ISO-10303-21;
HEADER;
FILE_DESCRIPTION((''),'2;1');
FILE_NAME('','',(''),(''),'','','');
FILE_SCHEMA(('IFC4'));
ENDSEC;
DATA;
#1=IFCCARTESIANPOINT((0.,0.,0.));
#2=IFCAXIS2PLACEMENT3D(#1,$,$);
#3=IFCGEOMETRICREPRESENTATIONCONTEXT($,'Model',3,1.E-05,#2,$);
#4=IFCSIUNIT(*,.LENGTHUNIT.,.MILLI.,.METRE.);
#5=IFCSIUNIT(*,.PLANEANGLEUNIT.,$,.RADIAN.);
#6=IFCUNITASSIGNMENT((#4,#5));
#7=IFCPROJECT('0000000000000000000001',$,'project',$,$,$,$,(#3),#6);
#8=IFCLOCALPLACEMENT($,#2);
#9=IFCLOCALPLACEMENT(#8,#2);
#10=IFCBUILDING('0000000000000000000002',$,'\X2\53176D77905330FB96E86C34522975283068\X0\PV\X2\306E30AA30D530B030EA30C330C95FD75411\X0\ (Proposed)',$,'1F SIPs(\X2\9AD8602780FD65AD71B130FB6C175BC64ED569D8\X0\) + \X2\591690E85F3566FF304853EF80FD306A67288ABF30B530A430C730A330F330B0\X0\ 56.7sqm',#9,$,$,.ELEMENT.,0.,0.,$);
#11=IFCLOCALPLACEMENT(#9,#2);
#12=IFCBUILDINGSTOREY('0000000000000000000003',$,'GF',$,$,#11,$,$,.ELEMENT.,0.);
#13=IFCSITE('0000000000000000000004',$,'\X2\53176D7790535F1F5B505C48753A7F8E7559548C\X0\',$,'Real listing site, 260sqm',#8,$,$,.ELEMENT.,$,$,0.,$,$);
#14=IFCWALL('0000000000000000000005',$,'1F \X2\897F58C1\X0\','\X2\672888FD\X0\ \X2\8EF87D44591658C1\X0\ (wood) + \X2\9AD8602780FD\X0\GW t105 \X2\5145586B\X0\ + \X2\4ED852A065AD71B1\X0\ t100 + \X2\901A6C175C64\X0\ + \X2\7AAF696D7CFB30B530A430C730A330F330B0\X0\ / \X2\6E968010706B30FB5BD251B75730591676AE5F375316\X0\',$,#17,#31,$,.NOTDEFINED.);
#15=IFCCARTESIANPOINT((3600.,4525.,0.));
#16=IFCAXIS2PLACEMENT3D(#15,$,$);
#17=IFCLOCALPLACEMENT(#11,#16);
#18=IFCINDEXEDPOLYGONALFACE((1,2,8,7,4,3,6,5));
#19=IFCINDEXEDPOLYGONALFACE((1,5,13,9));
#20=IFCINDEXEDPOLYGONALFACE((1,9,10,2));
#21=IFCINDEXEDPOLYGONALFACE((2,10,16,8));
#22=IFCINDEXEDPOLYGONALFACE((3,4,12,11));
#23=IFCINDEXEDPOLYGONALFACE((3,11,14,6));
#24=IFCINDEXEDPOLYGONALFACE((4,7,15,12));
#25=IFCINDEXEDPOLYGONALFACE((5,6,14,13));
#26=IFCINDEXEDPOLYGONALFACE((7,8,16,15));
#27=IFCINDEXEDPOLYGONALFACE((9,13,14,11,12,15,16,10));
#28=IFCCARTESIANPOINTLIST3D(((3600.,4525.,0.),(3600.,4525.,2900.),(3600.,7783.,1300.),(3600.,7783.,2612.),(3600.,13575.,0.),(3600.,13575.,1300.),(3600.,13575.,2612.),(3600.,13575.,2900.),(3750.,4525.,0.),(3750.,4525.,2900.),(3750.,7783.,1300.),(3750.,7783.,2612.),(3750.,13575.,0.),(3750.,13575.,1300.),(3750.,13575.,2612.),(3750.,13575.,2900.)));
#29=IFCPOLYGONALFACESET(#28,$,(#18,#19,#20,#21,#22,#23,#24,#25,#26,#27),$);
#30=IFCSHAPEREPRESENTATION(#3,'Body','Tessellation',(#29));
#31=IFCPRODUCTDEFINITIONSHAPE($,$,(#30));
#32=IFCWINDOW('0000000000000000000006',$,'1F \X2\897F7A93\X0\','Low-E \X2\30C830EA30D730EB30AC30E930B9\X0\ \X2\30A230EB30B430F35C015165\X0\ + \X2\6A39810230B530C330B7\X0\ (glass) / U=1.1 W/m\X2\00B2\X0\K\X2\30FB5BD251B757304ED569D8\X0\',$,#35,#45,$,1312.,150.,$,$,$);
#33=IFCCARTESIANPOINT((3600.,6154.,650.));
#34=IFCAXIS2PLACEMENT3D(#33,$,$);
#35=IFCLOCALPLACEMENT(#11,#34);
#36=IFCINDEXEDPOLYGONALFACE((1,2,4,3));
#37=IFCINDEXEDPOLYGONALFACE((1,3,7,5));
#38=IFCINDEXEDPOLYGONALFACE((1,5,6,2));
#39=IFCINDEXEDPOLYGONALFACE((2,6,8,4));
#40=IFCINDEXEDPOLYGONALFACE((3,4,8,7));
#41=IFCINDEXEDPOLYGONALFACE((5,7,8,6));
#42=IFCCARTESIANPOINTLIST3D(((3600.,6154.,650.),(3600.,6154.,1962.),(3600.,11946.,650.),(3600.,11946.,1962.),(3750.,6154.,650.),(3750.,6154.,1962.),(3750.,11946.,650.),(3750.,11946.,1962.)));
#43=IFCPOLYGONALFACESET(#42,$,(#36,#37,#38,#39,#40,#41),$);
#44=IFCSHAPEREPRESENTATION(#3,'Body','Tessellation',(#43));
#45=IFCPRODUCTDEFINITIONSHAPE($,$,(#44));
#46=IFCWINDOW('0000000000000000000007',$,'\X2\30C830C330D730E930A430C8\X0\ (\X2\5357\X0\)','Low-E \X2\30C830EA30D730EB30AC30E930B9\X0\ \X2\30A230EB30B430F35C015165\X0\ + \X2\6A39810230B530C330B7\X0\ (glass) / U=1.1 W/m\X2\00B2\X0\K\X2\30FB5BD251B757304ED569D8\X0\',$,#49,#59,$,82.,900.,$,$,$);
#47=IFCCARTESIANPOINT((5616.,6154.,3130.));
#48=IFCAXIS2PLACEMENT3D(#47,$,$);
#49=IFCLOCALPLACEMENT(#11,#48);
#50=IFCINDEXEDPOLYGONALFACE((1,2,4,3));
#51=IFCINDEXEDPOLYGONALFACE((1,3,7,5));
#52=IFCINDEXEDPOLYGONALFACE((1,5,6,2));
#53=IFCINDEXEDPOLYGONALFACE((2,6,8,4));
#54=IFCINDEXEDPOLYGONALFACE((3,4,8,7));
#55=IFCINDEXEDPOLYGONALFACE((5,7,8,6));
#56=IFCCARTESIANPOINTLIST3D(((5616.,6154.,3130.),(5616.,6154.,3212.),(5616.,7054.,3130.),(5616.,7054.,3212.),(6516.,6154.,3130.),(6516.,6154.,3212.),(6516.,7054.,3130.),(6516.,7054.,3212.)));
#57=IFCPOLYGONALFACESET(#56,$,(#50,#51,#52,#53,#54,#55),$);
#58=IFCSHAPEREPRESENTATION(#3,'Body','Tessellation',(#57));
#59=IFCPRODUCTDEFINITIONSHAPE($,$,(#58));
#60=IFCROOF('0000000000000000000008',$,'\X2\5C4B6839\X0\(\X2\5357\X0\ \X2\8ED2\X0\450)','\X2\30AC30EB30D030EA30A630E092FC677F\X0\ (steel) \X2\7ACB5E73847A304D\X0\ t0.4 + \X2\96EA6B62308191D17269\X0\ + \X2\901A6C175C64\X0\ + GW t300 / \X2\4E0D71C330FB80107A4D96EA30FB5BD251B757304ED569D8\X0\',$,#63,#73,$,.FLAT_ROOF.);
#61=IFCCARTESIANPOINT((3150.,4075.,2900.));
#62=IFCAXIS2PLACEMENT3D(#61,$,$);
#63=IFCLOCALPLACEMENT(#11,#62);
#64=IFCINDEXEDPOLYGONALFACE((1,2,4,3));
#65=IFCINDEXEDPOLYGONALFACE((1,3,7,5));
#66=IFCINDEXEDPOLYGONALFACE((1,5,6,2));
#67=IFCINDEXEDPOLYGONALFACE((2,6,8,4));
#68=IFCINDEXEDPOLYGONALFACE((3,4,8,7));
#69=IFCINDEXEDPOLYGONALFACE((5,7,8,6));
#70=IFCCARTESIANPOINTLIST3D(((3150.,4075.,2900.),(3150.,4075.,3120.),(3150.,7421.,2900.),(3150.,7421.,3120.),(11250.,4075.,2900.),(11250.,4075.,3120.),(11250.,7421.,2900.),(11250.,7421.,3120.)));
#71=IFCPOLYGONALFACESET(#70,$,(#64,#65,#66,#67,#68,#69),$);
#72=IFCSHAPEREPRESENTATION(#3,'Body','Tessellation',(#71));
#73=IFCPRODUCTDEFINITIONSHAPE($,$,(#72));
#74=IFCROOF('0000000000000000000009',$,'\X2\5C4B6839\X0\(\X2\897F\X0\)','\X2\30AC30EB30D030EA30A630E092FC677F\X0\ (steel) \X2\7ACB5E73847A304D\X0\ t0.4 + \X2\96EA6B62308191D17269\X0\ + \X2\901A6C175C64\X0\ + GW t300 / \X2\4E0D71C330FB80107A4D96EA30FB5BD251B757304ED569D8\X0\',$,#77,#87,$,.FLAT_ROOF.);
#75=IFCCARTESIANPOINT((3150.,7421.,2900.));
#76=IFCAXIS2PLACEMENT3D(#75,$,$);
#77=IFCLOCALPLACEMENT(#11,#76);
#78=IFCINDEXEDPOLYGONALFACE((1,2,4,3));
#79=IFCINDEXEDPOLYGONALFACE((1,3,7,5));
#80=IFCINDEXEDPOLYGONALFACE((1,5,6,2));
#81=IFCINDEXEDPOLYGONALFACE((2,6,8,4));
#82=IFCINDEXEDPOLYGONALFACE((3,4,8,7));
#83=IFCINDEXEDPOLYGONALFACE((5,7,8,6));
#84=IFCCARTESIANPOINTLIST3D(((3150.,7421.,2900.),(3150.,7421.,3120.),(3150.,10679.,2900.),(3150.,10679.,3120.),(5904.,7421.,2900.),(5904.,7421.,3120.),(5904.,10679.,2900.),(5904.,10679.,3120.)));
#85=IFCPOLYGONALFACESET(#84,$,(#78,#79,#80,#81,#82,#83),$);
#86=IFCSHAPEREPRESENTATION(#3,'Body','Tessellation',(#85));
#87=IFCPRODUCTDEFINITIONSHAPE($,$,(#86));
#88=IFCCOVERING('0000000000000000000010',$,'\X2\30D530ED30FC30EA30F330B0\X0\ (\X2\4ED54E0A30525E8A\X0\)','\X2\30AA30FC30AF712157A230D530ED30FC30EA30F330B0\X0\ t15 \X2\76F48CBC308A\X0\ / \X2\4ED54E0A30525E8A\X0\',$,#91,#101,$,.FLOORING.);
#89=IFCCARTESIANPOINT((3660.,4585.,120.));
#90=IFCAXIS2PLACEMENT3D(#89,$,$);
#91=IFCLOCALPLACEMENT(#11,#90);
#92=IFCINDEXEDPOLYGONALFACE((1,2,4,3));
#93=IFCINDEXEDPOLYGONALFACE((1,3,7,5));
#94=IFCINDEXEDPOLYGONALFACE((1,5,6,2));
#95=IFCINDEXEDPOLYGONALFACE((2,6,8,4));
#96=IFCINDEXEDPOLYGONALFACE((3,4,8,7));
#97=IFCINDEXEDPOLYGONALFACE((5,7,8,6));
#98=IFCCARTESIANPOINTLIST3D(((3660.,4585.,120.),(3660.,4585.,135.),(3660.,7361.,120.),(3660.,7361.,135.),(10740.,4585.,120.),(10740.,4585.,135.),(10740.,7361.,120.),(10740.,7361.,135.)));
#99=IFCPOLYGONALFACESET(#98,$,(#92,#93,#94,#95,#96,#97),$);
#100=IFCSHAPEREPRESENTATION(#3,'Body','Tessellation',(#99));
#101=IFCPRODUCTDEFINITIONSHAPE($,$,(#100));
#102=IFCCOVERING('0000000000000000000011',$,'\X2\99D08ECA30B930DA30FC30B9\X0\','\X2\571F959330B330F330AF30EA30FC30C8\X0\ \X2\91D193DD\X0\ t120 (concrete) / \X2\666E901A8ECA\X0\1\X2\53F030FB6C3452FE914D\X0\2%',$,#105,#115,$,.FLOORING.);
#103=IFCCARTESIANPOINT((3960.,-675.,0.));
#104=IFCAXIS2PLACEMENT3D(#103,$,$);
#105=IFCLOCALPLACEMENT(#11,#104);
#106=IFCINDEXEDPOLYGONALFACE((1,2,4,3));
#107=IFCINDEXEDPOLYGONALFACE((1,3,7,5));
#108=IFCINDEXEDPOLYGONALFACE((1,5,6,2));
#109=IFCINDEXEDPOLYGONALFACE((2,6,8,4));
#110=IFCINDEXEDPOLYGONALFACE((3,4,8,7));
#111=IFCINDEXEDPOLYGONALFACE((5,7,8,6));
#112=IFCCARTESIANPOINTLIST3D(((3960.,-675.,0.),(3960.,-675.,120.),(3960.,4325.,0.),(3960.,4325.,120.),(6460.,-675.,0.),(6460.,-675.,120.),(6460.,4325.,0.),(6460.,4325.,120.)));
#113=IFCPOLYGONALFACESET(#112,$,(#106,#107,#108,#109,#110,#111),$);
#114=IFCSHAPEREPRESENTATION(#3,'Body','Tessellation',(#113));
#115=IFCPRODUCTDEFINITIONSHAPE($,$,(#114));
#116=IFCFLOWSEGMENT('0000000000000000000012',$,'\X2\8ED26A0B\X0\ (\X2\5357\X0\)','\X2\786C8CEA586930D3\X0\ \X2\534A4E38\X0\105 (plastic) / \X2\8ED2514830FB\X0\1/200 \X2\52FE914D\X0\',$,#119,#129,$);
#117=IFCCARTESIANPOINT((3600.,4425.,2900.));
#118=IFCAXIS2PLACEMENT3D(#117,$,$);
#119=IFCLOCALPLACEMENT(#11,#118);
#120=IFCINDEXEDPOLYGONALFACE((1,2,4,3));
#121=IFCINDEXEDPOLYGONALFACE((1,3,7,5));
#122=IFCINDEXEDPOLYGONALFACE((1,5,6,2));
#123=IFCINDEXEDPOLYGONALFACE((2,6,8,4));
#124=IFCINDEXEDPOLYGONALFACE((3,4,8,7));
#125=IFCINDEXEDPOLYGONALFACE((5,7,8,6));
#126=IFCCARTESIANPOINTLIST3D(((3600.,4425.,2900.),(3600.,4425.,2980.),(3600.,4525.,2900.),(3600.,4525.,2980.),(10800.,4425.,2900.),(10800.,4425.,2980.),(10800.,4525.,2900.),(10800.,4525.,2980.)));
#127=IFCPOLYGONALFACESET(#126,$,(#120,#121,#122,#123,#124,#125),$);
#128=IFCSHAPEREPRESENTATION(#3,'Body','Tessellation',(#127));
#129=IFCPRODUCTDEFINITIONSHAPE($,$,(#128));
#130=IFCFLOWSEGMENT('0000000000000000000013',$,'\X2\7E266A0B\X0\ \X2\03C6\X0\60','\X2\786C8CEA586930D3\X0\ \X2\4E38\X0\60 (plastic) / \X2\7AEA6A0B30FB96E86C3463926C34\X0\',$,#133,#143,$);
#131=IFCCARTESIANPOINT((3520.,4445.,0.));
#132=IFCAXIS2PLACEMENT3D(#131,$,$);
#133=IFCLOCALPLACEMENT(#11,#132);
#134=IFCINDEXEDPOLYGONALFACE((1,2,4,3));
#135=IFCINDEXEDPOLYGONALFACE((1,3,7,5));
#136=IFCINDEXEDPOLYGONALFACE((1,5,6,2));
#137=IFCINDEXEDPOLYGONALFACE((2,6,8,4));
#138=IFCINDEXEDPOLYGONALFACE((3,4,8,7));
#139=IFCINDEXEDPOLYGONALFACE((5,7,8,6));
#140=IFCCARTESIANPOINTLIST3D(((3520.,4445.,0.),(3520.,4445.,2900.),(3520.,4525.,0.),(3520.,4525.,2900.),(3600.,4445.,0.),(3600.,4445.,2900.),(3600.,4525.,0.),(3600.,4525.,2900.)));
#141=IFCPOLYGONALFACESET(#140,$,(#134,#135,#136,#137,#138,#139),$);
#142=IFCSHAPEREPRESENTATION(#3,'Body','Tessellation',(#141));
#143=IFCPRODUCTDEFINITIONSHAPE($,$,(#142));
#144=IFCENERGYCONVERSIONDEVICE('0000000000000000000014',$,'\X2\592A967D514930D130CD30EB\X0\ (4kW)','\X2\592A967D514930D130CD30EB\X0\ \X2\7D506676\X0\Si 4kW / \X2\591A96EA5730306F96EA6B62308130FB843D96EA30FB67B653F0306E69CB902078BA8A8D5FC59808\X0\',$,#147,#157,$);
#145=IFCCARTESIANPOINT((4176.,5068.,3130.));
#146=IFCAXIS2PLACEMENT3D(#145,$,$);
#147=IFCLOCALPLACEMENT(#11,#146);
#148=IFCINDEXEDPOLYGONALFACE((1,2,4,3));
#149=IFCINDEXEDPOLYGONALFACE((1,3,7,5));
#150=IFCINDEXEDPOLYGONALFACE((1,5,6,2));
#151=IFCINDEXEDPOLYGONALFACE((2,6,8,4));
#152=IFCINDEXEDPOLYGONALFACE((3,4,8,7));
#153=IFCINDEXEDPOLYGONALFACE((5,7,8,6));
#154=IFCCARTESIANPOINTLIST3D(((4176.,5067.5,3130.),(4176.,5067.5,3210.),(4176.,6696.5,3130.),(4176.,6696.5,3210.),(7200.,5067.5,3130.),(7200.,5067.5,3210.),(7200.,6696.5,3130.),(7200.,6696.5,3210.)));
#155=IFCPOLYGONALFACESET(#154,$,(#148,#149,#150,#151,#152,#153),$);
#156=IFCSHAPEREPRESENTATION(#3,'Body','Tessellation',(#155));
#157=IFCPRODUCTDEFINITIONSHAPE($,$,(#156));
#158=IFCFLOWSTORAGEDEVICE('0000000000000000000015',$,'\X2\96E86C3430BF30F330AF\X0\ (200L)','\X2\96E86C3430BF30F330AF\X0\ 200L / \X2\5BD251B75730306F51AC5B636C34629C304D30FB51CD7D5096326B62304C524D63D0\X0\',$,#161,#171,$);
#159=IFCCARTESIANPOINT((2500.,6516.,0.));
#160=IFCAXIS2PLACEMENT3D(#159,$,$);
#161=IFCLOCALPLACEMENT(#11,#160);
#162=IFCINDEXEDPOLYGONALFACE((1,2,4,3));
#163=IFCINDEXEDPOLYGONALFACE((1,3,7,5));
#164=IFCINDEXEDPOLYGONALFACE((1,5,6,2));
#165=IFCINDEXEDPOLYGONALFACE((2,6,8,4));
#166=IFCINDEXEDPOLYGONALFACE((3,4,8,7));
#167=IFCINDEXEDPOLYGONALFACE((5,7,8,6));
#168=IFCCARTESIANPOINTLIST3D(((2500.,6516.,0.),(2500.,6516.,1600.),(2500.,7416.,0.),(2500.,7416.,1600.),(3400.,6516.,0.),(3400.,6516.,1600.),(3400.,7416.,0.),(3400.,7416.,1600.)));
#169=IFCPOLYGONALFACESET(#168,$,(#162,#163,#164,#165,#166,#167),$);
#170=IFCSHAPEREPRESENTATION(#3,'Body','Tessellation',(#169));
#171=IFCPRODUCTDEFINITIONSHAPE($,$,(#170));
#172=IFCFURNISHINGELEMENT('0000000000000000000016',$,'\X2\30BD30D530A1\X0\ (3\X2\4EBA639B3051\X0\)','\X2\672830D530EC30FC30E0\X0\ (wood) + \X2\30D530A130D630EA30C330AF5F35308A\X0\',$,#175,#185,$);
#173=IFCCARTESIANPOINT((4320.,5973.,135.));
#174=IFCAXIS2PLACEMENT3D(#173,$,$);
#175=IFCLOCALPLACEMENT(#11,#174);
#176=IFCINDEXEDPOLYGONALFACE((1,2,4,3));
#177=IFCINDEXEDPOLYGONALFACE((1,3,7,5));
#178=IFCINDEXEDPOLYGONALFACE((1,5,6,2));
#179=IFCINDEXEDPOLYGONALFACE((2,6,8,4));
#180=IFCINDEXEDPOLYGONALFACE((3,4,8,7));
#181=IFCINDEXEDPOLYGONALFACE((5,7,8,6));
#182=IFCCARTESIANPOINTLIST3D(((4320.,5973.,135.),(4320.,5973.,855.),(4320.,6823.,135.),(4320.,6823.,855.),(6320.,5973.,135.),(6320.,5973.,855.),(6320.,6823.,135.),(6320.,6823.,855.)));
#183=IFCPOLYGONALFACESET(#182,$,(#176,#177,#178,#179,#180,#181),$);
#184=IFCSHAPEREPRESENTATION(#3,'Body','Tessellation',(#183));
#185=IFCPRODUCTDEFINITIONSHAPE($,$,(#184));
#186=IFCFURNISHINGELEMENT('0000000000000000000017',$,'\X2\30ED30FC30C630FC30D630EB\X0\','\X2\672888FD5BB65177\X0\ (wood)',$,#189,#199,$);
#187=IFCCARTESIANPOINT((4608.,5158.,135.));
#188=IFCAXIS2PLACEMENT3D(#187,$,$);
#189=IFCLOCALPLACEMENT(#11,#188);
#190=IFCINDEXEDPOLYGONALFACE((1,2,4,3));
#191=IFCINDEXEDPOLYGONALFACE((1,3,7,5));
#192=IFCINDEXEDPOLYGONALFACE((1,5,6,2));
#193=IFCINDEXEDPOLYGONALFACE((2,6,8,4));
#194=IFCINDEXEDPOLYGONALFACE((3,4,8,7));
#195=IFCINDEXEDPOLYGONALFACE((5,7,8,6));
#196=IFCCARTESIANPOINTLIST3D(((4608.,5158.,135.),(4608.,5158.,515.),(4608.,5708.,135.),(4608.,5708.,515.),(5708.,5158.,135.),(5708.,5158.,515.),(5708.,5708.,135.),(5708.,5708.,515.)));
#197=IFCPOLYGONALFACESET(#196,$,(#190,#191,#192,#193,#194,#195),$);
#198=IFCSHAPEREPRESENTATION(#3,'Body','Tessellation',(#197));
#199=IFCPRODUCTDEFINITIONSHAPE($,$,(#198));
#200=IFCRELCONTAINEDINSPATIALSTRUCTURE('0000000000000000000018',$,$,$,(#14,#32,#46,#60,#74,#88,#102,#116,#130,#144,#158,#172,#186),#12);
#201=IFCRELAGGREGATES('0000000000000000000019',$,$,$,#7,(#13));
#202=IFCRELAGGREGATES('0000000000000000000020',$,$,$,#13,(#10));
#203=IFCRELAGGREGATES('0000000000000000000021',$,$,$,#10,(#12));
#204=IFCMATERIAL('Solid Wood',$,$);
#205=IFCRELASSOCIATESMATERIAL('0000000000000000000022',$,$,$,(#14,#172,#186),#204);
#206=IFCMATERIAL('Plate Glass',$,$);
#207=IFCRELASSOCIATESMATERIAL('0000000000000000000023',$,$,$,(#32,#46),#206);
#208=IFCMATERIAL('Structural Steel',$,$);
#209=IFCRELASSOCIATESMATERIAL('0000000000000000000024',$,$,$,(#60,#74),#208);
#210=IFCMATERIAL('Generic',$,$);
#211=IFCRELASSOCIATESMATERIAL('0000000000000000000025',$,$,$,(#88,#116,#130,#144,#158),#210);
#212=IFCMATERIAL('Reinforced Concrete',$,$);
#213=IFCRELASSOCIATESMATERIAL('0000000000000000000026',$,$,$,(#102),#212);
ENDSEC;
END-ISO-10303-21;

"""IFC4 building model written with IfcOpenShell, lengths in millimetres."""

from ifc_helpers import new_model, si_unit, frame, frame_2d, origin, place, context, project, spatial, rectangle, extrude, material, element, fill, save


model = new_model("IFC4")

# Units and contexts
model_context = context("Model", 3, precision=1e-05, world=origin())
ifc_project = project(units=[si_unit("LENGTHUNIT", "METRE", prefix="MILLI"), si_unit("PLANEANGLEUNIT", "RADIAN")], contexts=[model_context])

# Site, building, storey
site_placement = place(None, origin())
site = spatial("IfcSite", under=ifc_project, at=site_placement, Name="北海道弟子屈町美留和", ObjectType="Real listing site, 260sqm", CompositionType="ELEMENT", RefElevation=0.0)
building_placement = place(site_placement, origin())
building = spatial("IfcBuilding", under=site, at=building_placement, Name="北海道・雨水利用とPVのオフグリッド志向 (Proposed)", ObjectType="1F SIPs(高性能断熱・気密仕様) + 外部張替え可能な木調サイディング 56.7sqm", CompositionType="ELEMENT", ElevationOfRefHeight=0.0, ElevationOfTerrain=0.0)
storey_placement = place(building_placement, origin())
storey = spatial("IfcBuildingStorey", under=building, at=storey_placement, Name="GF", CompositionType="ELEMENT", Elevation=0.0)

# Shared definitions
ifc_material_1 = material(Name="Solid Wood")

# Shared definitions
ifc_material_2 = material(Name="Reinforced Concrete")

# Shared definitions
ifc_material_3 = material(Name="Plate Glass")

# Wall, opening, window
wall_1_placement = place(storey_placement, frame((3600.0, 4525.0, 0.0)))
wall_1 = element("IfcWall", 1, at=wall_1_placement, inside=storey, material=ifc_material_1, Name="1F 西壁", Description="木製 軸組外壁 (wood) + 高性能GW t105 充填 + 付加断熱 t100 + 通気層 + 窯業系サイディング / 準耐火・寒冷地外皮強化", PredefinedType="NOTDEFINED", context=model_context, shape_type="SweptSolid", body=[
    extrude(rectangle(XDim=150.0, YDim=9050.0, at=frame_2d((75.0, 4525.0))), frame((3600.0, 4525.0, 0.0)), (0.0, 0.0, 1.0), 2900.0),
])
opening_1_placement = place(storey_placement, frame((3600.0, 6154.0, 650.0)))
opening_1 = element("IfcOpeningElement", 2, at=opening_1_placement, cuts=wall_1, PredefinedType="NOTDEFINED", context=model_context, shape_type="SweptSolid", body=[
    extrude(rectangle(XDim=150.0, YDim=5792.0, at=frame_2d((75.0, 2896.0))), frame((3600.0, 6154.0, 650.0)), (0.0, 0.0, 1.0), 1312.0),
])
window_1_placement = place(storey_placement, frame((3600.0, 6154.0, 650.0)))
window_1 = element("IfcWindow", 3, at=window_1_placement, inside=storey, material=ifc_material_3, Name="1F 西窓", Description="Low-E トリプルガラス アルゴン封入 + 樹脂サッシ (glass) / U=1.1 W/m²K・寒冷地仕様", OverallHeight=1312.0, OverallWidth=150.0, context=model_context, shape_type="SweptSolid", body=[
    extrude(rectangle(XDim=150.0, YDim=5792.0, at=frame_2d((75.0, 2896.0))), frame((3600.0, 6154.0, 650.0)), (0.0, 0.0, 1.0), 1312.0),
])
fill(opening_1, window_1)

# Window
window_2_placement = place(storey_placement, frame((5616.0, 6154.0, 3130.0)))
element("IfcWindow", 4, at=window_2_placement, inside=storey, material=ifc_material_3, Name="トップライト (南)", Description="Low-E トリプルガラス アルゴン封入 + 樹脂サッシ (glass) / U=1.1 W/m²K・寒冷地仕様", OverallHeight=82.0, OverallWidth=900.0, context=model_context, shape_type="SweptSolid", body=[
    extrude(rectangle(XDim=900.0, YDim=900.0, at=frame_2d((450.0, 450.0))), frame((5616.0, 6154.0, 3130.0)), (0.0, 0.0, 1.0), 82.0),
])

# Roofs
ifc_material_4 = material(Name="Structural Steel")
roof_1_placement = place(storey_placement, frame((3150.0, 4075.0, 2900.0)))
element("IfcRoof", 5, at=roof_1_placement, inside=storey, material=ifc_material_4, Name="屋根(南 軒450)", Description="ガルバリウム鋼板 (steel) 立平葺き t0.4 + 雪止め金物 + 通気層 + GW t300 / 不燃・耐積雪・寒冷地仕様", PredefinedType="FLAT_ROOF", context=model_context, shape_type="SweptSolid", body=[
    extrude(rectangle(XDim=8100.0, YDim=3346.0, at=frame_2d((4050.0, 1673.0))), frame((3150.0, 4075.0, 2900.0)), (0.0, 0.0, 1.0), 220.0),
])
roof_2_placement = place(storey_placement, frame((3150.0, 7421.0, 2900.0)))
element("IfcRoof", 6, at=roof_2_placement, inside=storey, material=ifc_material_4, Name="屋根(西)", Description="ガルバリウム鋼板 (steel) 立平葺き t0.4 + 雪止め金物 + 通気層 + GW t300 / 不燃・耐積雪・寒冷地仕様", PredefinedType="FLAT_ROOF", context=model_context, shape_type="SweptSolid", body=[
    extrude(rectangle(XDim=2754.0, YDim=3258.0, at=frame_2d((1377.0, 1629.0))), frame((3150.0, 7421.0, 2900.0)), (0.0, 0.0, 1.0), 220.0),
])

# Coverings
ifc_material_5 = material(Name="Generic")
covering_1_placement = place(storey_placement, frame((3660.0, 4585.0, 120.0)))
element("IfcCovering", 7, at=covering_1_placement, inside=storey, material=ifc_material_5, Name="フローリング (仕上げ床)", Description="オーク無垢フローリング t15 直貼り / 仕上げ床", PredefinedType="FLOORING", context=model_context, shape_type="SweptSolid", body=[
    extrude(rectangle(XDim=7080.0, YDim=2776.0, at=frame_2d((3540.0, 1388.0))), frame((3660.0, 4585.0, 120.0)), (0.0, 0.0, 1.0), 15.0),
])
covering_2_placement = place(storey_placement, frame((3960.0, -675.0, 0.0)))
element("IfcCovering", 8, at=covering_2_placement, inside=storey, material=ifc_material_2, Name="駐車スペース", Description="土間コンクリート 金鏝 t120 (concrete) / 普通車1台・水勾配2%", PredefinedType="FLOORING", context=model_context, shape_type="SweptSolid", body=[
    extrude(rectangle(XDim=2500.0, YDim=5000.0, at=frame_2d((1250.0, 2500.0))), frame((3960.0, -675.0, 0.0)), (0.0, 0.0, 1.0), 120.0),
])

# Flow segments
flow_segment_1_placement = place(storey_placement, frame((3600.0, 4425.0, 2900.0)))
element("IfcFlowSegment", 9, at=flow_segment_1_placement, inside=storey, material=ifc_material_5, Name="軒樋 (南)", Description="硬質塩ビ 半丸105 (plastic) / 軒先・1/200 勾配", context=model_context, shape_type="SweptSolid", body=[
    extrude(rectangle(XDim=7200.0, YDim=100.0, at=frame_2d((3600.0, 50.0))), frame((3600.0, 4425.0, 2900.0)), (0.0, 0.0, 1.0), 80.0),
])
flow_segment_2_placement = place(storey_placement, frame((3520.0, 4445.0, 0.0)))
element("IfcFlowSegment", 10, at=flow_segment_2_placement, inside=storey, material=ifc_material_5, Name="縦樋 φ60", Description="硬質塩ビ 丸60 (plastic) / 竪樋・雨水排水", context=model_context, shape_type="SweptSolid", body=[
    extrude(rectangle(XDim=80.0, YDim=80.0, at=frame_2d((40.0, 40.0))), frame((3520.0, 4445.0, 0.0)), (0.0, 0.0, 1.0), 2900.0),
])

# Energy conversion device
energy_conversion_device_placement = place(storey_placement, frame((4176.0, 5068.0, 3130.0)))
element("IfcEnergyConversionDevice", 11, at=energy_conversion_device_placement, inside=storey, material=ifc_material_5, Name="太陽光パネル (4kW)", Description="太陽光パネル 結晶Si 4kW / 多雪地は雪止め・落雪・架台の構造確認必須", context=model_context, shape_type="SweptSolid", body=[
    extrude(rectangle(XDim=3024.0, YDim=1629.0, at=frame_2d((1512.0, 814.0))), frame((4176.0, 5068.0, 3130.0)), (0.0, 0.0, 1.0), 80.0),
])

# Flow storage device
flow_storage_device_placement = place(storey_placement, frame((2500.0, 6516.0, 0.0)))
element("IfcFlowStorageDevice", 12, at=flow_storage_device_placement, inside=storey, material=ifc_material_5, Name="雨水タンク (200L)", Description="雨水タンク 200L / 寒冷地は冬季水抜き・凍結防止が前提", context=model_context, shape_type="SweptSolid", body=[
    extrude(rectangle(XDim=900.0, YDim=900.0, at=frame_2d((450.0, 450.0))), frame((2500.0, 6516.0, 0.0)), (0.0, 0.0, 1.0), 1600.0),
])

# Furnishing elements
furnishing_1_placement = place(storey_placement, frame((4320.0, 5973.0, 135.0)))
element("IfcFurnishingElement", 13, at=furnishing_1_placement, inside=storey, material=ifc_material_1, Name="ソファ (3人掛け)", Description="木フレーム (wood) + ファブリック張り", context=model_context, shape_type="SweptSolid", body=[
    extrude(rectangle(XDim=2000.0, YDim=850.0, at=frame_2d((1000.0, 425.0))), frame((4320.0, 5973.0, 135.0)), (0.0, 0.0, 1.0), 720.0),
])
furnishing_2_placement = place(storey_placement, frame((4608.0, 5158.0, 135.0)))
element("IfcFurnishingElement", 14, at=furnishing_2_placement, inside=storey, material=ifc_material_1, Name="ローテーブル", Description="木製家具 (wood)", context=model_context, shape_type="SweptSolid", body=[
    extrude(rectangle(XDim=1100.0, YDim=550.0, at=frame_2d((550.0, 275.0))), frame((4608.0, 5158.0, 135.0)), (0.0, 0.0, 1.0), 380.0),
])

save(model, "model.ifc")
